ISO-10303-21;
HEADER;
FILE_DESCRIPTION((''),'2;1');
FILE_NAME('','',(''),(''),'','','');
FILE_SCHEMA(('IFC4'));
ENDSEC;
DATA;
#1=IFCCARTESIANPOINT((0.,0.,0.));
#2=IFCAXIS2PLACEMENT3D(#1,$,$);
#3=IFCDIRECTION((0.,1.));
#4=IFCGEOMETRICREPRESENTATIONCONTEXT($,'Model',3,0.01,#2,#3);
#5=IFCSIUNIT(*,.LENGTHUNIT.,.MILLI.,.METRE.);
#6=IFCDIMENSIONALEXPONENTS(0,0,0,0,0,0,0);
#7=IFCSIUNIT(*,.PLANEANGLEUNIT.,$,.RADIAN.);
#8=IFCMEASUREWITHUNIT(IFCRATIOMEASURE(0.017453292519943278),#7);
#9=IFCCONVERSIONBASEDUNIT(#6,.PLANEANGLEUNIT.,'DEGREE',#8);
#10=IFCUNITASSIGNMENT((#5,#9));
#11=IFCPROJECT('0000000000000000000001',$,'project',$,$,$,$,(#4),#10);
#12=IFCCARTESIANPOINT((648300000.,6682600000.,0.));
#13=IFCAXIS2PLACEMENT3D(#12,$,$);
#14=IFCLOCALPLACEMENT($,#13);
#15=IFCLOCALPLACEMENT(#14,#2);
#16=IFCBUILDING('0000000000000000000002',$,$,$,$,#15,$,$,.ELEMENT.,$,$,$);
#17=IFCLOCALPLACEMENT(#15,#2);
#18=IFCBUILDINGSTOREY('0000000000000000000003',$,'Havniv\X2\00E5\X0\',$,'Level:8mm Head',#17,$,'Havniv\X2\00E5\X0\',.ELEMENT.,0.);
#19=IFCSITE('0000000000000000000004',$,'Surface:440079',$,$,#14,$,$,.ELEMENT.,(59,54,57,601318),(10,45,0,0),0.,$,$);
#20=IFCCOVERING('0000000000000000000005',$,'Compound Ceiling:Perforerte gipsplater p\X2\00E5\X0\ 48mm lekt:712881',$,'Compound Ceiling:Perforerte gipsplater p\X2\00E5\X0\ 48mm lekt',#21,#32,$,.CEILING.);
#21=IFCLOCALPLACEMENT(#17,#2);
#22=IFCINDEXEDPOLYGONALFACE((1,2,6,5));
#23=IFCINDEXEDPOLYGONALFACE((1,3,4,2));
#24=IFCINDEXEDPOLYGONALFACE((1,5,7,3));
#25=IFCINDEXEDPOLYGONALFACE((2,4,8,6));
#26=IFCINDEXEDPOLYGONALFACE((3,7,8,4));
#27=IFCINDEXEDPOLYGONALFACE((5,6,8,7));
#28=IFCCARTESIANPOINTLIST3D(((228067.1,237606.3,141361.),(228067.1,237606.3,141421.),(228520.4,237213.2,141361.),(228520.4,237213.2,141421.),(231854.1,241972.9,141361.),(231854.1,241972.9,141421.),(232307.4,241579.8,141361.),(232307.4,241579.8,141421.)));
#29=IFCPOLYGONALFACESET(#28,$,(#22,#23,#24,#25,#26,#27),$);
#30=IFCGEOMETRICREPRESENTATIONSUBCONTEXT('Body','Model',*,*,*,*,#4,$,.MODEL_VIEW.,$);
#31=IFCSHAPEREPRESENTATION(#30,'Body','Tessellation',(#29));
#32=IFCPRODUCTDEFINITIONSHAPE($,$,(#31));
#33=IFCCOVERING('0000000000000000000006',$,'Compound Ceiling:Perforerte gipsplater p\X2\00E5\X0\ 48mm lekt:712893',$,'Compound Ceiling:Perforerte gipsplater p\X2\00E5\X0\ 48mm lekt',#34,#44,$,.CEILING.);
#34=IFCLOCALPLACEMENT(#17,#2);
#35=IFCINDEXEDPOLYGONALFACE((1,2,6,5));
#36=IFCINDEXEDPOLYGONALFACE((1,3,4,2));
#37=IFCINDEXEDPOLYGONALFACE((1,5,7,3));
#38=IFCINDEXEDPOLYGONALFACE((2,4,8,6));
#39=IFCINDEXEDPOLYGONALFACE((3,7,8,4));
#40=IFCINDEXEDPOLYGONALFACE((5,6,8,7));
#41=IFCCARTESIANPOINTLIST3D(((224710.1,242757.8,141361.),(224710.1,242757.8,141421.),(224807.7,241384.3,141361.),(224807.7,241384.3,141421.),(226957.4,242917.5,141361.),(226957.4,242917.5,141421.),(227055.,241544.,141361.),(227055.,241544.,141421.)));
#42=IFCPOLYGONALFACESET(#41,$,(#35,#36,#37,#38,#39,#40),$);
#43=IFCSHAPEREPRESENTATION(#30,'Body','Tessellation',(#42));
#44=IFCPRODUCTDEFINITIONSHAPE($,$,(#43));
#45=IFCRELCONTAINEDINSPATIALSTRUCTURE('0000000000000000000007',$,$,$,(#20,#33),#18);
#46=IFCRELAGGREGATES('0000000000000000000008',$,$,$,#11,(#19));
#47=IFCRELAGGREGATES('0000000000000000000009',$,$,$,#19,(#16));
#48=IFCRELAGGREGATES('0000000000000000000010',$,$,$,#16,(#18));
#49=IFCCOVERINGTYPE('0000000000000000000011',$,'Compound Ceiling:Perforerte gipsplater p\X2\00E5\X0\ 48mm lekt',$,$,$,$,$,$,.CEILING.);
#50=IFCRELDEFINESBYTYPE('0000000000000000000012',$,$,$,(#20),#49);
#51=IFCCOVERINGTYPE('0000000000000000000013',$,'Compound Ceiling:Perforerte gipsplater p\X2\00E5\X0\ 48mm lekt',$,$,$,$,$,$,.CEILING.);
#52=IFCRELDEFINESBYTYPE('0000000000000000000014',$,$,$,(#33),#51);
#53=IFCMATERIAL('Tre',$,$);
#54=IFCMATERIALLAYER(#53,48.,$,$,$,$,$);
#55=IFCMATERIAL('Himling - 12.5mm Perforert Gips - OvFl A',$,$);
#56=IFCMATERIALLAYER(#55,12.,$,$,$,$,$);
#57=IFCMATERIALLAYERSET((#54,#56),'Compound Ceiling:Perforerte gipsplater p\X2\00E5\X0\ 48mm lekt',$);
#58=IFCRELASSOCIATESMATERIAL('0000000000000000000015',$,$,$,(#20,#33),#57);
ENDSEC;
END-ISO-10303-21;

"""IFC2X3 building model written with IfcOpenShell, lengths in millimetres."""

from ifc_helpers import new_model, entity, si_unit, converted_unit, direction, frame, frame_2d, origin, place, context, subcontext, project, spatial, rectangle, extrude, material, layer, layer_set, layer_usage, type_object, element, save


model = new_model("IFC2X3")

# Units and contexts
model_context = context("Model", 3, precision=0.01, world=origin(), true_north=direction((0.0, 1.0)))
body_context = subcontext(model_context, "Body", "Model", "MODEL_VIEW")
ifc_project = project(units=[si_unit("LENGTHUNIT", "METRE", prefix="MILLI"), converted_unit("PLANEANGLEUNIT", "DEGREE", entity("IfcRatioMeasure", 0.017453292519943278), si_unit("PLANEANGLEUNIT", "RADIAN"), dimensions=[0, 0, 0, 0, 0, 0, 0])], contexts=[model_context])

# Site, building, storey
site_placement = place(None, frame((648300000.0, 6682600000.0, 0.0)))
site = spatial("IfcSite", under=ifc_project, at=site_placement, Name="Surface:440079", CompositionType="ELEMENT", RefLatitude=(59, 54, 57, 601318), RefLongitude=(10, 45, 0, 0), RefElevation=0.0)
building_placement = place(site_placement, origin())
building = spatial("IfcBuilding", under=site, at=building_placement, CompositionType="ELEMENT")
storey_placement = place(building_placement, origin())
storey = spatial("IfcBuildingStorey", under=building, at=storey_placement, Name="Havnivå", ObjectType="Level:8mm Head", LongName="Havnivå", CompositionType="ELEMENT", Elevation=0.0)

# Coverings
ifc_material_1 = material(Name="Tre")
ifc_layer_1 = layer(ifc_material_1, 48.0)
ifc_material_2 = material(Name="Himling - 12.5mm Perforert Gips - OvFl A")
ifc_layer_2 = layer(ifc_material_2, 12.0)
ifc_layer_set_1 = layer_set([ifc_layer_1, ifc_layer_2], Name="Compound Ceiling:Perforerte gipsplater på 48mm lekt")
ifc_layer_usage_1 = layer_usage(ifc_layer_set_1, "AXIS3", "POSITIVE", 0.0)
covering_type_1 = type_object("IfcCoveringType", Name="Compound Ceiling:Perforerte gipsplater på 48mm lekt", PredefinedType="CEILING")
covering_1_placement = place(storey_placement, origin())
element("IfcCovering", 1, at=covering_1_placement, inside=storey, type_object=covering_type_1, material=ifc_layer_usage_1, Name="Compound Ceiling:Perforerte gipsplater på 48mm lekt:712881", ObjectType="Compound Ceiling:Perforerte gipsplater på 48mm lekt", PredefinedType="CEILING", context=body_context, shape_type="SweptSolid", body=[
    extrude(rectangle(XDim=600.0, YDim=5780.0, at=frame_2d((0.0, 0.0), x_axis=(1.0, 0.0))), frame((230187.3, 239593.0, 141361.0), z_axis=(0.0, 0.0, 1.0), x_axis=(0.755467, -0.655187, 0.0)), (0.0, 0.0, 1.0), 60.0),
])
ifc_layer_usage_2 = layer_usage(ifc_layer_set_1, "AXIS3", "POSITIVE", 0.0)
covering_type_2 = type_object("IfcCoveringType", Name="Compound Ceiling:Perforerte gipsplater på 48mm lekt", PredefinedType="CEILING")
covering_2_placement = place(storey_placement, origin())
element("IfcCovering", 2, at=covering_2_placement, inside=storey, type_object=covering_type_2, material=ifc_layer_usage_2, Name="Compound Ceiling:Perforerte gipsplater på 48mm lekt:712893", ObjectType="Compound Ceiling:Perforerte gipsplater på 48mm lekt", PredefinedType="CEILING", context=body_context, shape_type="SweptSolid", body=[
    extrude(rectangle(XDim=1377.0, YDim=2253.0, at=frame_2d((0.0, 0.0), x_axis=(1.0, 0.0))), frame((225882.5, 242150.9, 141361.0), z_axis=(0.0, 0.0, 1.0), x_axis=(0.070908, -0.997483, 0.0)), (0.0, 0.0, 1.0), 60.0),
])

save(model, "model.ifc")
